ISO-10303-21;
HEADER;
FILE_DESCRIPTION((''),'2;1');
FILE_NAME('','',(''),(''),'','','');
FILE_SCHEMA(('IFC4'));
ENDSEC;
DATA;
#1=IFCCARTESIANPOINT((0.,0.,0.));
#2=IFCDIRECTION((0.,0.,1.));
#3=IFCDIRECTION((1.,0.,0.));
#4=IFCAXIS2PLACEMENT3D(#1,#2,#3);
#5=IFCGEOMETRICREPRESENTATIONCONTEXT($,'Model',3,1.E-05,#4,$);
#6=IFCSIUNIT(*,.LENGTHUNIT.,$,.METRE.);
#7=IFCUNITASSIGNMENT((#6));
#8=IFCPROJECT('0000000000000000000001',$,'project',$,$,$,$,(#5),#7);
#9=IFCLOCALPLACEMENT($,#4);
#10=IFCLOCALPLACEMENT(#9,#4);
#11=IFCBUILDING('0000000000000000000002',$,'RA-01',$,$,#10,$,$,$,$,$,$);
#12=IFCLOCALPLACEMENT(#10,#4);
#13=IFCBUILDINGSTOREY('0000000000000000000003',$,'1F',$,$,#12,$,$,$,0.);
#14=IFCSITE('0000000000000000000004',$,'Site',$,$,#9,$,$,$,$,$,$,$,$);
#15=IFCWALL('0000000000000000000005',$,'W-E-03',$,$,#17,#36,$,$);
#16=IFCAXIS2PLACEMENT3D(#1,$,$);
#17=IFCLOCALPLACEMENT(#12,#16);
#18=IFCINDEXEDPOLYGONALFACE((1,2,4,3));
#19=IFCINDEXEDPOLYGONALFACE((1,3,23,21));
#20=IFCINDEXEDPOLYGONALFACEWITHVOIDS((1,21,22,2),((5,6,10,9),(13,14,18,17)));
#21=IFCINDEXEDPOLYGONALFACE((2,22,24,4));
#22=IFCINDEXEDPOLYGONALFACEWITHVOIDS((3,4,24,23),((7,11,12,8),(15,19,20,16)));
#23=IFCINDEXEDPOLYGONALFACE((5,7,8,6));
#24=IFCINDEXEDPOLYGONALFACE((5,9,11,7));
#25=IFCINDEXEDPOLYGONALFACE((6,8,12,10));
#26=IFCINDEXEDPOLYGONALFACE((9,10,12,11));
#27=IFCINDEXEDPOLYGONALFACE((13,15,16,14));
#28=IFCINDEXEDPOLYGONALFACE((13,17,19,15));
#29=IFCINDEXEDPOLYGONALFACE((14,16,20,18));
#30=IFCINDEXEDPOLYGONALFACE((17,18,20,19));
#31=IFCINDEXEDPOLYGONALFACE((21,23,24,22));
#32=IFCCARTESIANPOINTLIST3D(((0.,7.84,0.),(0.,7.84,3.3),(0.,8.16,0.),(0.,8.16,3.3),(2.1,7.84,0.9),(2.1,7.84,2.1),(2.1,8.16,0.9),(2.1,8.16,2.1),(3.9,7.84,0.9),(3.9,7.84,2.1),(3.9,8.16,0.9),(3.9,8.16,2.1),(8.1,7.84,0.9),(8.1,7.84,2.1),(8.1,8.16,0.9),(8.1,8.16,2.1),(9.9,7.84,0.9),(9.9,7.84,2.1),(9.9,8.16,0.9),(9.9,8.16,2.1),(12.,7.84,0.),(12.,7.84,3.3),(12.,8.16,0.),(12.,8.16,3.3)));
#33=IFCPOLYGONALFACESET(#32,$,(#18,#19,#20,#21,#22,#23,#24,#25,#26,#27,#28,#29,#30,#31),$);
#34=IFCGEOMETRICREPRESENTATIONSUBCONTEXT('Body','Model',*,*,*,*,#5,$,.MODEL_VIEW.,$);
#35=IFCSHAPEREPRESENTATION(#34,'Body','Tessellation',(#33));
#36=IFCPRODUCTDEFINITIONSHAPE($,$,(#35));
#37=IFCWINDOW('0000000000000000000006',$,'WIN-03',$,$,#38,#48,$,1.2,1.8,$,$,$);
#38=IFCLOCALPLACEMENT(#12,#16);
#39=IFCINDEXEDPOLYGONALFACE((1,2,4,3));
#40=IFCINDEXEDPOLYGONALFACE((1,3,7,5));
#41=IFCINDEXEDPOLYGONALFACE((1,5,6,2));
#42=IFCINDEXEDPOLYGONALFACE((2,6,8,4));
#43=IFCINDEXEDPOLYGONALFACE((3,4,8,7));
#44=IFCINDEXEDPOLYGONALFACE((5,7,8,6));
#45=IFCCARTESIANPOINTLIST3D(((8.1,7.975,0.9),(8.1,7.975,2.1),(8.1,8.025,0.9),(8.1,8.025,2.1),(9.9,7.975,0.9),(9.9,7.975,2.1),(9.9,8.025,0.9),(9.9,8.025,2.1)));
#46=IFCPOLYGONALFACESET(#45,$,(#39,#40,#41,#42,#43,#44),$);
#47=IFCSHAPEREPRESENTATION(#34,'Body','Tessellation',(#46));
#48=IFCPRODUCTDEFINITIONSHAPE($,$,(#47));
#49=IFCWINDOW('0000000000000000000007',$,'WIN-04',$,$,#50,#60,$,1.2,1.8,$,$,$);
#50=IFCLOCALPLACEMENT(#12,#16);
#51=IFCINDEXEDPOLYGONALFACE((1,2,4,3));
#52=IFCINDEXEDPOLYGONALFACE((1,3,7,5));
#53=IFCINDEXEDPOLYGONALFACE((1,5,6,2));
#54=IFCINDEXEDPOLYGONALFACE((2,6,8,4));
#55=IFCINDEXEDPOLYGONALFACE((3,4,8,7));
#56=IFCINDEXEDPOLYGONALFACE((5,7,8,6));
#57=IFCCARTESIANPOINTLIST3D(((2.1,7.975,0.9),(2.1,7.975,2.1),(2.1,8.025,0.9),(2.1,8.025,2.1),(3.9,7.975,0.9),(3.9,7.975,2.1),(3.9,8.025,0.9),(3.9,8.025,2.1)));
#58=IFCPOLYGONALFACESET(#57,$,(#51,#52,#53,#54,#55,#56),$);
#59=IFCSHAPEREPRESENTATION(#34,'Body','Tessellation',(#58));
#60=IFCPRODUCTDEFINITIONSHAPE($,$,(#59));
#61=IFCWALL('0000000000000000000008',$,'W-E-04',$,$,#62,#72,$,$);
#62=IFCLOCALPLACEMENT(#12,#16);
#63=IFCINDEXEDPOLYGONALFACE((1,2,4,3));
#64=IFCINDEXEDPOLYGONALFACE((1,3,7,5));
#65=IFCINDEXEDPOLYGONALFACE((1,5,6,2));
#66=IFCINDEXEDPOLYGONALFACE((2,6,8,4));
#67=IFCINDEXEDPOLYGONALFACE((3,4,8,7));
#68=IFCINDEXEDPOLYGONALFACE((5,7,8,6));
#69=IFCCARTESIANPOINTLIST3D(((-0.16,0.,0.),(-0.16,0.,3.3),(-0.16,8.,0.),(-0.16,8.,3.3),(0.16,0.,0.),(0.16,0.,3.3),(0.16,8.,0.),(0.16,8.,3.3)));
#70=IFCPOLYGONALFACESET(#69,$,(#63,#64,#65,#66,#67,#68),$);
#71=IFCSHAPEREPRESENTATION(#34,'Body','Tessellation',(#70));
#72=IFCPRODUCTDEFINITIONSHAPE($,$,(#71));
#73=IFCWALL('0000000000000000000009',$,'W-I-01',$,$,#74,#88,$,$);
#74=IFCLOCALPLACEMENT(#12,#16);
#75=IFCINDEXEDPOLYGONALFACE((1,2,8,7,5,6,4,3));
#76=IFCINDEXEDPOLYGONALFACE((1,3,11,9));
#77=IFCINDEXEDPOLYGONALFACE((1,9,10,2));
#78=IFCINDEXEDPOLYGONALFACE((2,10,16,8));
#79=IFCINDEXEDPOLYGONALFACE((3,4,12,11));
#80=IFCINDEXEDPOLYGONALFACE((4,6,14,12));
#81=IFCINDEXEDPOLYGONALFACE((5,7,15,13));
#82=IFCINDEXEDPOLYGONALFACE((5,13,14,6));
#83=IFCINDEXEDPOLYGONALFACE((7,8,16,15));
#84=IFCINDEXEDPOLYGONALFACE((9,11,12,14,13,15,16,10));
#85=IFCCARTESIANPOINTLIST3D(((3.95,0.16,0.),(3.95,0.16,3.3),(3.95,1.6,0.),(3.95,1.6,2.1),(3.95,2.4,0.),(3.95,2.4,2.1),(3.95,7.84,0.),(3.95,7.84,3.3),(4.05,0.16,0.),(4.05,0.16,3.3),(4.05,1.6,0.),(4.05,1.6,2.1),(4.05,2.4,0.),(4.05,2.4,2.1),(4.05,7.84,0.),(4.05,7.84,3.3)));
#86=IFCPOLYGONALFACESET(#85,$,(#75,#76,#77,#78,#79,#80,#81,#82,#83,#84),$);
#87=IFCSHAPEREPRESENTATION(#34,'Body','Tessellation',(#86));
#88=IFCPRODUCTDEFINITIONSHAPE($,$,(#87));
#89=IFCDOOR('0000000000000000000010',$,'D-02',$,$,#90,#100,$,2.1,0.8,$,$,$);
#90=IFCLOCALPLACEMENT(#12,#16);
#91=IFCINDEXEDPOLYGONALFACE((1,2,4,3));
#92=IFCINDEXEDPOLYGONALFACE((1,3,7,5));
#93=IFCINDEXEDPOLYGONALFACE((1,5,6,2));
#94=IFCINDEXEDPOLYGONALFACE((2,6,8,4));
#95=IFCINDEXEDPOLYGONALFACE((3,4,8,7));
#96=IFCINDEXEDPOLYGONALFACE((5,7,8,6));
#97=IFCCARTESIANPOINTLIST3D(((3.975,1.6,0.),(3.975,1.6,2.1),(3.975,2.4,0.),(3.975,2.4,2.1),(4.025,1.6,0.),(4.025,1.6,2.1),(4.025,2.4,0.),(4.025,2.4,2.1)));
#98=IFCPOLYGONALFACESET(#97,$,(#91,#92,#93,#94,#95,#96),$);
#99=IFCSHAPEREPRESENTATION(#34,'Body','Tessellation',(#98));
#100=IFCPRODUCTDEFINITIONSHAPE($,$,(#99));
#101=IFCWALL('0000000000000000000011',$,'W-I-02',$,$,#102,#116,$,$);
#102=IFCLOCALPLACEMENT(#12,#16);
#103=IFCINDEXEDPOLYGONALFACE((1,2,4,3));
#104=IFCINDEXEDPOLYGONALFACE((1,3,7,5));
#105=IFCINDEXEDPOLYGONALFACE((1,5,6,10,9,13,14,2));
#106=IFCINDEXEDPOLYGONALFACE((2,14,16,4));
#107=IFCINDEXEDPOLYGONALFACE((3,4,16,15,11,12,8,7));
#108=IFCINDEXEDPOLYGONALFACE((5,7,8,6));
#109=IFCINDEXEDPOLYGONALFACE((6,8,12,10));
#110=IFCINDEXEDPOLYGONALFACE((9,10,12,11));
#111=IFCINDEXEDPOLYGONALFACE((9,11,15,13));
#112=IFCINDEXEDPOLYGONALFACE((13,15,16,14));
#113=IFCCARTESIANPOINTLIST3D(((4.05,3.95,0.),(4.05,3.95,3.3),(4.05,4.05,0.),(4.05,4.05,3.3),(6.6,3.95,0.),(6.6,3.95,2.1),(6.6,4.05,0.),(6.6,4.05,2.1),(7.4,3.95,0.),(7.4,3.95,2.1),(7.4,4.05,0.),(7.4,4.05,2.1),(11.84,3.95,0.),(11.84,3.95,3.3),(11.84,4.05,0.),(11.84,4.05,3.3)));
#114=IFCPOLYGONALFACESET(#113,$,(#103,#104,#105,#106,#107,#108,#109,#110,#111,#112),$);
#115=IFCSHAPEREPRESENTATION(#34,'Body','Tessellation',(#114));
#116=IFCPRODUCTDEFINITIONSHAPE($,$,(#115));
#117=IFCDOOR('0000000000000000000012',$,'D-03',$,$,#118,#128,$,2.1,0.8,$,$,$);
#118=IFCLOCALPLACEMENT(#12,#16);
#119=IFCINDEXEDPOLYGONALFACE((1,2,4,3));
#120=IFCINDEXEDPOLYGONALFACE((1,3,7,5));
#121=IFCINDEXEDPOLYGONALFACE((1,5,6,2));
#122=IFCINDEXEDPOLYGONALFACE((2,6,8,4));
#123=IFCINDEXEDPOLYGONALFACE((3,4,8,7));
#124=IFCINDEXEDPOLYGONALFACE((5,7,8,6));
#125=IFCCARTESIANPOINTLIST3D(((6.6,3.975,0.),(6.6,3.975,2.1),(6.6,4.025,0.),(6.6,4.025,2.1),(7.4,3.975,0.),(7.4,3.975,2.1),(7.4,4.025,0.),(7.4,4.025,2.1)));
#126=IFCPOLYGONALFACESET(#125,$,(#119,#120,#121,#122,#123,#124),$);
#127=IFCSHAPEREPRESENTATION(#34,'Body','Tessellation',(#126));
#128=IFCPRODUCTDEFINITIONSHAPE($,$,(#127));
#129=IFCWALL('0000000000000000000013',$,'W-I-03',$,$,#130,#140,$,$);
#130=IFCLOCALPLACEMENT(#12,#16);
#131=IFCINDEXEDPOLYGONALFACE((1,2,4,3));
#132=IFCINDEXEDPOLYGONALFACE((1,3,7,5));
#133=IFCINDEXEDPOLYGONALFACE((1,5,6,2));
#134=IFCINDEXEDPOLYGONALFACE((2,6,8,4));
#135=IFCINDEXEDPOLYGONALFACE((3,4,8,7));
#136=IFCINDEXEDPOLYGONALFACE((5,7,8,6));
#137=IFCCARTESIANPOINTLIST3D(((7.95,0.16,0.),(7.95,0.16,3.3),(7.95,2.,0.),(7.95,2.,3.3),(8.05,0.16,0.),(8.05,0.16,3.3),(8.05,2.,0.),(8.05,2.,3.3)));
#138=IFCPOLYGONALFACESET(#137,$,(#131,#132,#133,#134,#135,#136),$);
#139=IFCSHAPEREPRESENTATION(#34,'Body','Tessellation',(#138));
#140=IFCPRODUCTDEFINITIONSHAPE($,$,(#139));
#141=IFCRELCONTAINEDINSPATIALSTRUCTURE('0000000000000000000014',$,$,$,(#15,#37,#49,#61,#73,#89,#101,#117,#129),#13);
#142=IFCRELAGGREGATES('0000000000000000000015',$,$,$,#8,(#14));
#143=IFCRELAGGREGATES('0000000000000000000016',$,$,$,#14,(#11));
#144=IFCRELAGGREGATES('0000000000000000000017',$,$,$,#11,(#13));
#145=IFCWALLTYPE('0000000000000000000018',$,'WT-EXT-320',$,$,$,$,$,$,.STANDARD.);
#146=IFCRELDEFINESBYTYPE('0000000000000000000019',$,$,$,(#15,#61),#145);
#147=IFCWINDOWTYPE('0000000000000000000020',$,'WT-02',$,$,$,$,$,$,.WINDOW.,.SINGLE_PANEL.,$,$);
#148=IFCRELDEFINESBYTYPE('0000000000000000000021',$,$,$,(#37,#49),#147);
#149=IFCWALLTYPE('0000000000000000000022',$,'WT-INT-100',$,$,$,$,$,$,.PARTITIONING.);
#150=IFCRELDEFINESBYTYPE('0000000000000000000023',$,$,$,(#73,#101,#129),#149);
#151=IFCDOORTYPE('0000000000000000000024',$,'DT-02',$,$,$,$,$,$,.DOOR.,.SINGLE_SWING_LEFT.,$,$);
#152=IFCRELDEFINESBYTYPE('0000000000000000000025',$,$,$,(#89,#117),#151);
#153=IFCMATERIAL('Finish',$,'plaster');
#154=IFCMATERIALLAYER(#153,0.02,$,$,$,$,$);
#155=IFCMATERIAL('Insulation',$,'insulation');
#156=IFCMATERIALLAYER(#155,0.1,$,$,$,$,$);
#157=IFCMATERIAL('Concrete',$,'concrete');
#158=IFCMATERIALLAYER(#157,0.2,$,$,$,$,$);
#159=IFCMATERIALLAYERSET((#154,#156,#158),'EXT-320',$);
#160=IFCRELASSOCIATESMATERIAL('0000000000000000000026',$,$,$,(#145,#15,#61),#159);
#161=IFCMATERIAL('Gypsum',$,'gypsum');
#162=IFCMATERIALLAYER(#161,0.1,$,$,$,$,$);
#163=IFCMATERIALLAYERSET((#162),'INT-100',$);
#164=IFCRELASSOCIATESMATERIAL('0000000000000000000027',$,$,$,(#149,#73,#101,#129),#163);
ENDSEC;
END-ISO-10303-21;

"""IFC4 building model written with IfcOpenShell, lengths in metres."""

from ifc_helpers import new_model, si_unit, frame, frame_2d, origin_with_axes, origin_2d_with_axis, place, context, subcontext, project, spatial, rectangle, extrude, material, layer, layer_set, layer_usage, type_object, element, fill, save


model = new_model("IFC4")

# Units and contexts
model_context = context("Model", 3, precision=1e-05, world=origin_with_axes())
body_context = subcontext(model_context, "Body", "Model", "MODEL_VIEW")
ifc_project = project(units=[si_unit("LENGTHUNIT", "METRE")], contexts=[model_context])

# Site, building, storey
site_placement = place(None, origin_with_axes())
site = spatial("IfcSite", under=ifc_project, at=site_placement, Name="Site")
building_placement = place(site_placement, origin_with_axes())
building = spatial("IfcBuilding", under=site, at=building_placement, Name="RA-01")
storey_placement = place(building_placement, origin_with_axes())
storey = spatial("IfcBuildingStorey", under=building, at=storey_placement, Name="1F", Elevation=0.0)

# Shared definitions
ifc_material_1 = material(Name="Concrete", Category="concrete")

# Shared definitions
ifc_material_2 = material(Name="Finish", Category="plaster")
ifc_layer_1 = layer(ifc_material_2, 0.02)
ifc_material_3 = material(Name="Insulation", Category="insulation")
ifc_layer_2 = layer(ifc_material_3, 0.1)
ifc_layer_3 = layer(ifc_material_1, 0.2)
ifc_layer_set_1 = layer_set([ifc_layer_1, ifc_layer_2, ifc_layer_3], Name="EXT-320")
wall_type_1 = type_object("IfcWallType", Name="WT-EXT-320", PredefinedType="STANDARD", material=ifc_layer_set_1)

# Wall, openings, windows
ifc_layer_usage_1 = layer_usage(ifc_layer_set_1, "AXIS2", "POSITIVE", -0.16)
wall_1_placement = place(storey_placement, frame((12.0, 8.0, 0.0), z_axis=(0.0, 0.0, 1.0), x_axis=(-1.0, 0.0, 0.0)))
wall_1 = element("IfcWall", 1, at=wall_1_placement, inside=storey, type_object=wall_type_1, material=ifc_layer_usage_1, Name="W-E-03", context=body_context, shape_type="SweptSolid", body=[
    extrude(rectangle(XDim=12.0, YDim=0.32, at=frame_2d((6.0, 0.0), x_axis=(1.0, 0.0))), origin_with_axes(), (0.0, 0.0, 1.0), 3.3),
])
opening_1_placement = place(wall_1_placement, frame((3.0, 0.0, 0.9), z_axis=(0.0, 0.0, 1.0), x_axis=(1.0, 0.0, 0.0)))
opening_1 = element("IfcOpeningElement", 2, at=opening_1_placement, cuts=wall_1, PredefinedType="OPENING", context=body_context, shape_type="SweptSolid", body=[
    extrude(rectangle(XDim=1.8, YDim=0.42, at=origin_2d_with_axis()), origin_with_axes(), (0.0, 0.0, 1.0), 1.2),
])
opening_2_placement = place(wall_1_placement, frame((9.0, 0.0, 0.9), z_axis=(0.0, 0.0, 1.0), x_axis=(1.0, 0.0, 0.0)))
opening_2 = element("IfcOpeningElement", 3, at=opening_2_placement, cuts=wall_1, PredefinedType="OPENING", context=body_context, shape_type="SweptSolid", body=[
    extrude(rectangle(XDim=1.8, YDim=0.42, at=origin_2d_with_axis()), origin_with_axes(), (0.0, 0.0, 1.0), 1.2),
])
window_type_1 = type_object("IfcWindowType", Name="WT-02", PartitioningType="SINGLE_PANEL", PredefinedType="WINDOW")
window_1_placement = place(opening_1_placement, origin_with_axes())
window_1 = element("IfcWindow", 4, at=window_1_placement, inside=storey, type_object=window_type_1, Name="WIN-03", OverallHeight=1.2, OverallWidth=1.8, context=body_context, shape_type="SweptSolid", body=[
    extrude(rectangle(XDim=1.8, YDim=0.05, at=origin_2d_with_axis()), origin_with_axes(), (0.0, 0.0, 1.0), 1.2),
])
fill(opening_1, window_1)
window_2_placement = place(opening_2_placement, origin_with_axes())
window_2 = element("IfcWindow", 5, at=window_2_placement, inside=storey, type_object=window_type_1, Name="WIN-04", OverallHeight=1.2, OverallWidth=1.8, context=body_context, shape_type="SweptSolid", body=[
    extrude(rectangle(XDim=1.8, YDim=0.05, at=origin_2d_with_axis()), origin_with_axes(), (0.0, 0.0, 1.0), 1.2),
])
fill(opening_2, window_2)

# Wall
ifc_layer_usage_2 = layer_usage(ifc_layer_set_1, "AXIS2", "POSITIVE", -0.16)
wall_2_placement = place(storey_placement, frame((0.0, 8.0, 0.0), z_axis=(0.0, 0.0, 1.0), x_axis=(0.0, -1.0, 0.0)))
element("IfcWall", 6, at=wall_2_placement, inside=storey, type_object=wall_type_1, material=ifc_layer_usage_2, Name="W-E-04", context=body_context, shape_type="SweptSolid", body=[
    extrude(rectangle(XDim=8.0, YDim=0.32, at=frame_2d((4.0, 0.0), x_axis=(1.0, 0.0))), origin_with_axes(), (0.0, 0.0, 1.0), 3.3),
])

# Walls, openings, doors
ifc_material_4 = material(Name="Gypsum", Category="gypsum")
ifc_layer_4 = layer(ifc_material_4, 0.1)
ifc_layer_set_2 = layer_set([ifc_layer_4], Name="INT-100")
ifc_layer_usage_3 = layer_usage(ifc_layer_set_2, "AXIS2", "POSITIVE", -0.05)
wall_type_2 = type_object("IfcWallType", Name="WT-INT-100", PredefinedType="PARTITIONING", material=ifc_layer_set_2)
wall_3_placement = place(storey_placement, frame((4.0, 0.16, 0.0), z_axis=(0.0, 0.0, 1.0), x_axis=(0.0, 1.0, 0.0)))
wall_3 = element("IfcWall", 7, at=wall_3_placement, inside=storey, type_object=wall_type_2, material=ifc_layer_usage_3, Name="W-I-01", context=body_context, shape_type="SweptSolid", body=[
    extrude(rectangle(XDim=7.68, YDim=0.1, at=frame_2d((3.84, 0.0), x_axis=(1.0, 0.0))), origin_with_axes(), (0.0, 0.0, 1.0), 3.3),
])
opening_3_placement = place(wall_3_placement, frame((1.84, 0.0, 0.0), z_axis=(0.0, 0.0, 1.0), x_axis=(1.0, 0.0, 0.0)))
opening_3 = element("IfcOpeningElement", 8, at=opening_3_placement, cuts=wall_3, PredefinedType="OPENING", context=body_context, shape_type="SweptSolid", body=[
    extrude(rectangle(XDim=0.8, YDim=0.2, at=origin_2d_with_axis()), origin_with_axes(), (0.0, 0.0, 1.0), 2.1),
])
door_type_1 = type_object("IfcDoorType", Name="DT-02", OperationType="SINGLE_SWING_LEFT", PredefinedType="DOOR")
door_1_placement = place(opening_3_placement, origin_with_axes())
door_1 = element("IfcDoor", 9, at=door_1_placement, inside=storey, type_object=door_type_1, Name="D-02", OverallHeight=2.1, OverallWidth=0.8, context=body_context, shape_type="SweptSolid", body=[
    extrude(rectangle(XDim=0.8, YDim=0.05, at=origin_2d_with_axis()), origin_with_axes(), (0.0, 0.0, 1.0), 2.1),
])
fill(opening_3, door_1)
ifc_layer_usage_4 = layer_usage(ifc_layer_set_2, "AXIS2", "POSITIVE", -0.05)
wall_4_placement = place(storey_placement, frame((4.05, 4.0, 0.0), z_axis=(0.0, 0.0, 1.0), x_axis=(1.0, 0.0, 0.0)))
wall_4 = element("IfcWall", 10, at=wall_4_placement, inside=storey, type_object=wall_type_2, material=ifc_layer_usage_4, Name="W-I-02", context=body_context, shape_type="SweptSolid", body=[
    extrude(rectangle(XDim=7.79, YDim=0.1, at=frame_2d((3.895, 0.0), x_axis=(1.0, 0.0))), origin_with_axes(), (0.0, 0.0, 1.0), 3.3),
])
opening_4_placement = place(wall_4_placement, frame((2.95, 0.0, 0.0), z_axis=(0.0, 0.0, 1.0), x_axis=(1.0, 0.0, 0.0)))
opening_4 = element("IfcOpeningElement", 11, at=opening_4_placement, cuts=wall_4, PredefinedType="OPENING", context=body_context, shape_type="SweptSolid", body=[
    extrude(rectangle(XDim=0.8, YDim=0.2, at=origin_2d_with_axis()), origin_with_axes(), (0.0, 0.0, 1.0), 2.1),
])
door_2_placement = place(opening_4_placement, origin_with_axes())
door_2 = element("IfcDoor", 12, at=door_2_placement, inside=storey, type_object=door_type_1, Name="D-03", OverallHeight=2.1, OverallWidth=0.8, context=body_context, shape_type="SweptSolid", body=[
    extrude(rectangle(XDim=0.8, YDim=0.05, at=origin_2d_with_axis()), origin_with_axes(), (0.0, 0.0, 1.0), 2.1),
])
fill(opening_4, door_2)

# Wall
ifc_layer_usage_5 = layer_usage(ifc_layer_set_2, "AXIS2", "POSITIVE", -0.05)
wall_5_placement = place(storey_placement, frame((8.0, 0.16, 0.0), z_axis=(0.0, 0.0, 1.0), x_axis=(0.0, 1.0, 0.0)))
element("IfcWall", 13, at=wall_5_placement, inside=storey, type_object=wall_type_2, material=ifc_layer_usage_5, Name="W-I-03", context=body_context, shape_type="SweptSolid", body=[
    extrude(rectangle(XDim=1.84, YDim=0.1, at=frame_2d((0.92, 0.0), x_axis=(1.0, 0.0))), origin_with_axes(), (0.0, 0.0, 1.0), 3.3),
])

save(model, "model.ifc")
